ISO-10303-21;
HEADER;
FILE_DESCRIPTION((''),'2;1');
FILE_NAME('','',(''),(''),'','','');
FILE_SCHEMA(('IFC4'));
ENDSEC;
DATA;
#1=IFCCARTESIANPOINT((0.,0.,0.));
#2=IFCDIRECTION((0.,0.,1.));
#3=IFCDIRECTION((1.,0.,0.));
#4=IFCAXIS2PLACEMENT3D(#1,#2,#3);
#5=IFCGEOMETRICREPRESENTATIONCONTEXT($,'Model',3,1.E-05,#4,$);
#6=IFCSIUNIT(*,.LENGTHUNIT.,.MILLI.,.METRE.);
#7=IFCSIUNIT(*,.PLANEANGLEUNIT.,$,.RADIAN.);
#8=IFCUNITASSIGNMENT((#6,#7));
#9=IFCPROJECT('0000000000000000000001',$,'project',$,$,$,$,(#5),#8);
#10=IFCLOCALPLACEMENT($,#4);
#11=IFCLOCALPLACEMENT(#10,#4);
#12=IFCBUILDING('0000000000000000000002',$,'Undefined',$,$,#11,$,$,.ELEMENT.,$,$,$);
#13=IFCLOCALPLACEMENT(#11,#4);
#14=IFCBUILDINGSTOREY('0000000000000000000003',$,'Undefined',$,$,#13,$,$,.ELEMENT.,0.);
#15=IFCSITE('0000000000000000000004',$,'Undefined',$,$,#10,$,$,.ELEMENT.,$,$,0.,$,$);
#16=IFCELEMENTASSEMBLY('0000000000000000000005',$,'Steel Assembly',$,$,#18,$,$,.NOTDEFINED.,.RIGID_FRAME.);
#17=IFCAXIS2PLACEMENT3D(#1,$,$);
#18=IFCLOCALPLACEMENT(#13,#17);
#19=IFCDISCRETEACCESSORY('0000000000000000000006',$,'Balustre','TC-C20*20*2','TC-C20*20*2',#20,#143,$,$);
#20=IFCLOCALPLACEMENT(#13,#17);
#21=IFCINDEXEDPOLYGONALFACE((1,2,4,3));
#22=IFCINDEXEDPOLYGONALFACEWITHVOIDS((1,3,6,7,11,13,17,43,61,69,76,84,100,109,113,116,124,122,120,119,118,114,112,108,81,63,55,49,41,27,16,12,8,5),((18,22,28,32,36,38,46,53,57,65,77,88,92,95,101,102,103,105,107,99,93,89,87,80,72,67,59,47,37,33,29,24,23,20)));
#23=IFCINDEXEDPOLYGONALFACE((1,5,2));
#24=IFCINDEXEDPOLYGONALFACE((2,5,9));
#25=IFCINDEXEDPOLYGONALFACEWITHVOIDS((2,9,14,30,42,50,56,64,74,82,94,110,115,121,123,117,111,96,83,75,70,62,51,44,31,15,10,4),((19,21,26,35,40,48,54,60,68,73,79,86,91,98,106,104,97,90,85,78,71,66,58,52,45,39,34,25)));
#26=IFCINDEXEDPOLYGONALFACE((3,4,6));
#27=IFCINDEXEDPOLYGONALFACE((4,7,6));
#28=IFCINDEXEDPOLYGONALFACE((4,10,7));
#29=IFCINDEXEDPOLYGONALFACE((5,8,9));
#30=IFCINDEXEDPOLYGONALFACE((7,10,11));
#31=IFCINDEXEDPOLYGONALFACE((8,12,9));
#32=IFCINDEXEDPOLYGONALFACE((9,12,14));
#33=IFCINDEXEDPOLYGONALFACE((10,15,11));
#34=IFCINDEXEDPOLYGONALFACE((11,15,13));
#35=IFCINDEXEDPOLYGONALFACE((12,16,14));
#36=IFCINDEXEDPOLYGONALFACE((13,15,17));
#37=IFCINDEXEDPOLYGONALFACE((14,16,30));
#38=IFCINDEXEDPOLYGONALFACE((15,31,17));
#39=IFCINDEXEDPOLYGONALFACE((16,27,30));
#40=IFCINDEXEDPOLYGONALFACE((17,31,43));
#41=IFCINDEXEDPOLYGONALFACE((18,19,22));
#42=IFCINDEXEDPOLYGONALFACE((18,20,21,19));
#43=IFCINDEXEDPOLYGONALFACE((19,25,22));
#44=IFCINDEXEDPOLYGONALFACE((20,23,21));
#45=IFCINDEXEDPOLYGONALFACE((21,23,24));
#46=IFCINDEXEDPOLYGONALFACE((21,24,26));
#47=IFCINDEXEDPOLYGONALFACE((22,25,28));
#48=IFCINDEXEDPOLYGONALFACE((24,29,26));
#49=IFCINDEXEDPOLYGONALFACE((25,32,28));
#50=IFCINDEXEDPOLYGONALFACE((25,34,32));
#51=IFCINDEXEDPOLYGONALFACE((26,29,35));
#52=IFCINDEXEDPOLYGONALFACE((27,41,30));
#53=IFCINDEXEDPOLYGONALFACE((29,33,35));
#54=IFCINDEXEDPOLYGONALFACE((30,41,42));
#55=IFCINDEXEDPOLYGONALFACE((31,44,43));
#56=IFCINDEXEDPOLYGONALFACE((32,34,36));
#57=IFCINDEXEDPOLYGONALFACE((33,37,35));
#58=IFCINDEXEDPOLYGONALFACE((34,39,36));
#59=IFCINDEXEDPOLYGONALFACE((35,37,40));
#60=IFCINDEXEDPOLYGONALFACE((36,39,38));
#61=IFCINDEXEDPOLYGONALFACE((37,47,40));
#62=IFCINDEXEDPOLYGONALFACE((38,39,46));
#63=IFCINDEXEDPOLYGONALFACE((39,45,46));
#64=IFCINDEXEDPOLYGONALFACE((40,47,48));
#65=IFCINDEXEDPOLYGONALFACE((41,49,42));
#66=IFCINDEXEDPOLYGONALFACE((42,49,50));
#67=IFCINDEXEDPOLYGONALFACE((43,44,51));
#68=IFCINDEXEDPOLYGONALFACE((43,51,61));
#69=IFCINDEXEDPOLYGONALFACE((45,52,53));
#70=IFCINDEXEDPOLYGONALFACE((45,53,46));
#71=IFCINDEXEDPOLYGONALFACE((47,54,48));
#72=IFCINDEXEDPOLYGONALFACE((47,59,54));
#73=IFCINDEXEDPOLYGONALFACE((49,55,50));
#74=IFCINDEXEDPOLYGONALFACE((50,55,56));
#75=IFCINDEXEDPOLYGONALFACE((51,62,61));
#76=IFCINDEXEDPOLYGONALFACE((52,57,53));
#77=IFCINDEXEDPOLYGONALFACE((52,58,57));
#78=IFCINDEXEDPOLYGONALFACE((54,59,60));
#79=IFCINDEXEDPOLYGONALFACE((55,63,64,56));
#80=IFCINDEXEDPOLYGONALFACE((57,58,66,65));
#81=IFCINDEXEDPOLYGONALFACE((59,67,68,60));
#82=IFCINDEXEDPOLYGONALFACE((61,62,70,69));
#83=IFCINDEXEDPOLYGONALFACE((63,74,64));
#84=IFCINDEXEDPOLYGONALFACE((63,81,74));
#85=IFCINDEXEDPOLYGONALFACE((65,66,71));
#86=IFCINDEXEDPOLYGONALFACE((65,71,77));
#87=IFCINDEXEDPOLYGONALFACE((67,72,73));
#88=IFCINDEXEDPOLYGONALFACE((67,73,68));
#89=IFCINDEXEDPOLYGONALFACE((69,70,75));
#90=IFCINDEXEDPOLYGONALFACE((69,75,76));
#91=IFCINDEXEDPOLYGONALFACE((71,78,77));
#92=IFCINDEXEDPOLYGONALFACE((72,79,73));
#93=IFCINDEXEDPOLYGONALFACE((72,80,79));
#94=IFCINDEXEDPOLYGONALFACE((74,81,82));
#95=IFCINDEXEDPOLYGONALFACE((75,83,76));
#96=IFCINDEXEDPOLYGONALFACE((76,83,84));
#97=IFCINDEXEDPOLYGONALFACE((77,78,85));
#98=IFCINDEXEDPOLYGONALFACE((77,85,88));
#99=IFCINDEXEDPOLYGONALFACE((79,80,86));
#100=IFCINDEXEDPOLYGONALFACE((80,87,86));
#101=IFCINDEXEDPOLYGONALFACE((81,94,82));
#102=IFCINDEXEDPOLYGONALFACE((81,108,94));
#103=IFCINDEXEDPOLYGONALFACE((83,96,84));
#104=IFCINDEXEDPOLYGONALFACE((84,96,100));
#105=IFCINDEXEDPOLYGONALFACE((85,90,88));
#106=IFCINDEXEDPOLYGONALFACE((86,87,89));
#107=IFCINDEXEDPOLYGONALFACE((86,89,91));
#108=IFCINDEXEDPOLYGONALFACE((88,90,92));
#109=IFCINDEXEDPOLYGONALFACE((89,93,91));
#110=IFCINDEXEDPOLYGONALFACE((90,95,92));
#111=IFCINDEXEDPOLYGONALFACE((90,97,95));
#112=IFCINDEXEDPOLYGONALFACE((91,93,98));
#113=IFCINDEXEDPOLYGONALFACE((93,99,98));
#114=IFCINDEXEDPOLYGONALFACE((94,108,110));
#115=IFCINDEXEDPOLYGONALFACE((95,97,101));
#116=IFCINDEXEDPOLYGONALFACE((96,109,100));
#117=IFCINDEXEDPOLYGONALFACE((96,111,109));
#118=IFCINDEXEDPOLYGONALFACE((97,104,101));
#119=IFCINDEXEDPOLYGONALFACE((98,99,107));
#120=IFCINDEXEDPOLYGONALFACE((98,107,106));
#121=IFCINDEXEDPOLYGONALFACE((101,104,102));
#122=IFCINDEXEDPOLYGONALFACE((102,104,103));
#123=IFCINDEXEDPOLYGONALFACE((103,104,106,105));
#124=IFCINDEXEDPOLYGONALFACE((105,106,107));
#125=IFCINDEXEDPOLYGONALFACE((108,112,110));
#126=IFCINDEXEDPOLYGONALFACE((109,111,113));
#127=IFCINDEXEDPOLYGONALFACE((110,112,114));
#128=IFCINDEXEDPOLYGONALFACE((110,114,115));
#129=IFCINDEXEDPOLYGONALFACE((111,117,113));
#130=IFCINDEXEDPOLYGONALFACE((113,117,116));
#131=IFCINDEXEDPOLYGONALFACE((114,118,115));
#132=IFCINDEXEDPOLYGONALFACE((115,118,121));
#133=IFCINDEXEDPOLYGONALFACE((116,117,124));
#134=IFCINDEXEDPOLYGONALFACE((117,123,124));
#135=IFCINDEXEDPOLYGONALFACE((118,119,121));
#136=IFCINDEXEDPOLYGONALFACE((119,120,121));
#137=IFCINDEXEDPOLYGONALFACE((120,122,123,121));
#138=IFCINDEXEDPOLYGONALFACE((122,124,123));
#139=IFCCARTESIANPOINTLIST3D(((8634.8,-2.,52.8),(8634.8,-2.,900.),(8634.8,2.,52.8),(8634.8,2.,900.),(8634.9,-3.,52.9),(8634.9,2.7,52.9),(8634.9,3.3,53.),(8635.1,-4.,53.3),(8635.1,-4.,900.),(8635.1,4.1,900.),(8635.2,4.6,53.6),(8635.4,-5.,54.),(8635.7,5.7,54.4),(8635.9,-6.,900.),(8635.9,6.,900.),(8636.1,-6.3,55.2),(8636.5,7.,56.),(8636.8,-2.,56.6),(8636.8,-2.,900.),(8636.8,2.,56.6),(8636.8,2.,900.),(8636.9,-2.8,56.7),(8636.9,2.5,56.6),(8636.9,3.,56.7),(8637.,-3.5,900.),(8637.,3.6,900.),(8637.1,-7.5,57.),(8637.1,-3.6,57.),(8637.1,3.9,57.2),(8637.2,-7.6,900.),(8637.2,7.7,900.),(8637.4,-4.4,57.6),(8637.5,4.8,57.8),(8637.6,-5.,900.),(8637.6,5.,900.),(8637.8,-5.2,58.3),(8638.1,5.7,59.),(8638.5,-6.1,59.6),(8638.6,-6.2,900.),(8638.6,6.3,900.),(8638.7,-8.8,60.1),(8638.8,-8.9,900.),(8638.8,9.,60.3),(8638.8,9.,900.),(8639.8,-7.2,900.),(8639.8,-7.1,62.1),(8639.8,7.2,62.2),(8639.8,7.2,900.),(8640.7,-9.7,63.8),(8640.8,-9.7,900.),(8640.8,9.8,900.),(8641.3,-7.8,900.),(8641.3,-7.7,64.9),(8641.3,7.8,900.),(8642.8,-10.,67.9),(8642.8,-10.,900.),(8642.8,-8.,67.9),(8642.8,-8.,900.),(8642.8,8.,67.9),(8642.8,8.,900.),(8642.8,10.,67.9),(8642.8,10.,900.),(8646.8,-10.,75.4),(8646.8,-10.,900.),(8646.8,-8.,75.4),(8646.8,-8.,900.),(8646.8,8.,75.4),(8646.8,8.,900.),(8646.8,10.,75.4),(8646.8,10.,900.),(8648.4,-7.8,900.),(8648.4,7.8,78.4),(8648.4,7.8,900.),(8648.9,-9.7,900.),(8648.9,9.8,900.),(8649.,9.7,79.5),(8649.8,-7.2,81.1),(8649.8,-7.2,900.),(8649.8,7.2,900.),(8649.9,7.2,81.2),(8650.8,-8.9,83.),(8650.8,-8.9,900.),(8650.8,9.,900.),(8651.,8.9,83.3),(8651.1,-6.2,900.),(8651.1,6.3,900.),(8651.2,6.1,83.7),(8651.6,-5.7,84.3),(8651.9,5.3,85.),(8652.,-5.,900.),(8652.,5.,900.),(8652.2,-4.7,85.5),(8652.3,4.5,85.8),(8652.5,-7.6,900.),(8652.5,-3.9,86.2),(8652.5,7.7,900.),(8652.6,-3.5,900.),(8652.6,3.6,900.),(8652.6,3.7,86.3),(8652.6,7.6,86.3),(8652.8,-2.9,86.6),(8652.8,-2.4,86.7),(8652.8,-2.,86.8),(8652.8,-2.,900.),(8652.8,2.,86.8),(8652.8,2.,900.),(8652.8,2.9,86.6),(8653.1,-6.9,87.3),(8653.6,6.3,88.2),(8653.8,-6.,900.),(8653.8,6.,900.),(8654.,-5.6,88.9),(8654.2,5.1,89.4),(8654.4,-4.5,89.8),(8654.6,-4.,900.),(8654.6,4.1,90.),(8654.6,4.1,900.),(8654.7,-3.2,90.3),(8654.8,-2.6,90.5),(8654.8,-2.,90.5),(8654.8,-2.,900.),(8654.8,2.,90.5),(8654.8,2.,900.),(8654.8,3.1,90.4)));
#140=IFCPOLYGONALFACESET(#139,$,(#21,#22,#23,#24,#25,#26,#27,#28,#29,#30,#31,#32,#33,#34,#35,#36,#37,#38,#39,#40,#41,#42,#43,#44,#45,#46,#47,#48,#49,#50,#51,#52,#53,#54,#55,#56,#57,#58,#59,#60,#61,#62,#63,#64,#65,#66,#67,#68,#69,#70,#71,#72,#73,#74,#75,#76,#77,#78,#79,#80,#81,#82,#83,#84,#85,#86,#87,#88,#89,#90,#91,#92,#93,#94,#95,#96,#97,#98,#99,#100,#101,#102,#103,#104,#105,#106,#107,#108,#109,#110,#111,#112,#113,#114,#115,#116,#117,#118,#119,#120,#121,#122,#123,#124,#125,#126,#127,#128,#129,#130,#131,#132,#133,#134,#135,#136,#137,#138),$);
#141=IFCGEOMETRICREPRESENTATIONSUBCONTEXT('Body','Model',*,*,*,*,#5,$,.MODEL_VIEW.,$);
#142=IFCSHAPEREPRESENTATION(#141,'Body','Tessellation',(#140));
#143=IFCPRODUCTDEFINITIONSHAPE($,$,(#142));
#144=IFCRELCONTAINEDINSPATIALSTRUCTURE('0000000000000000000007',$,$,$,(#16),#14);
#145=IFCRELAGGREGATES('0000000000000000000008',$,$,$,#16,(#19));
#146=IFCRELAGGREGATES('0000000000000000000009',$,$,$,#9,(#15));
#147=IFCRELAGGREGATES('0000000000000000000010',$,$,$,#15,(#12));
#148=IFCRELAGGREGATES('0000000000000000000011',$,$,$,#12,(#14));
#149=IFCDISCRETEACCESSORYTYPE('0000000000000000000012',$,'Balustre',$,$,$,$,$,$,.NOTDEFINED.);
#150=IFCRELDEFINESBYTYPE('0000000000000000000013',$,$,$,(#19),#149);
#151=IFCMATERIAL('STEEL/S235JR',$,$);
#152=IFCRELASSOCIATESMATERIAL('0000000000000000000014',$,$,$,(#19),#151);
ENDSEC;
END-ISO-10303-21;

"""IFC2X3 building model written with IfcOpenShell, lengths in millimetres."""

from ifc_helpers import new_model, si_unit, frame, origin_with_axes, origin_2d_with_axis, place, context, subcontext, project, spatial, hollow_rectangle, extrude, clip, halfspace, material, type_object, element, aggregate, save


model = new_model("IFC2X3")

# Units and contexts
model_context = context("Model", 3, precision=1e-05, world=origin_with_axes())
body_context = subcontext(model_context, "Body", "Model", "MODEL_VIEW")
ifc_project = project(units=[si_unit("LENGTHUNIT", "METRE", prefix="MILLI"), si_unit("PLANEANGLEUNIT", "RADIAN")], contexts=[model_context])

# Site, building, storey
site_placement = place(None, origin_with_axes())
site = spatial("IfcSite", under=ifc_project, at=site_placement, Name="Undefined", CompositionType="ELEMENT", RefElevation=0.0)
building_placement = place(site_placement, origin_with_axes())
building = spatial("IfcBuilding", under=site, at=building_placement, Name="Undefined", CompositionType="ELEMENT")
storey_placement = place(building_placement, origin_with_axes())
storey = spatial("IfcBuildingStorey", under=building, at=storey_placement, Name="Undefined", CompositionType="ELEMENT", Elevation=0.0)

# Shared definitions
ifc_material = material(Name="STEEL/S235JR")

# Shared definitions
discrete_accessory_type_1 = type_object("IfcDiscreteAccessoryType", Name="Balustre")

# Element assembly, discrete accessory
assembly_1_placement = place(storey_placement, origin_with_axes())
assembly_1 = element("IfcElementAssembly", 1, at=assembly_1_placement, inside=storey, Name="Steel Assembly", AssemblyPlace="NOTDEFINED", PredefinedType="RIGID_FRAME")
discrete_accessory_1_placement = place(assembly_1_placement, frame((8644.8, 0.0, 900.0), z_axis=(-0.000011, 1.0, 0.0), x_axis=(0.0, 0.0, -1.0)))
discrete_accessory_1 = element("IfcDiscreteAccessory", 2, at=discrete_accessory_1_placement, type_object=discrete_accessory_type_1, material=ifc_material, Name="Balustre", Description="TC-C20*20*2", ObjectType="TC-C20*20*2", context=body_context, shape_type="Clipping", body=[
    clip(extrude(hollow_rectangle(XDim=20.0, YDim=20.0, WallThickness=2.0, InnerFilletRadius=6.0, OuterFilletRadius=8.0, at=origin_2d_with_axis()), frame((847.4, 0.0, 0.0), z_axis=(-1.0, 0.0, 0.0), x_axis=(0.0, -1.0, 0.0)), (0.0, 0.0, 1.0), 847.4), halfspace(frame((855.2, 14.2, 0.0), z_axis=(-0.46842, 0.883506, 0.000005), x_axis=(0.0, -0.000005, 1.0)), True)),
])

aggregate(assembly_1, [discrete_accessory_1])

save(model, "model.ifc")
